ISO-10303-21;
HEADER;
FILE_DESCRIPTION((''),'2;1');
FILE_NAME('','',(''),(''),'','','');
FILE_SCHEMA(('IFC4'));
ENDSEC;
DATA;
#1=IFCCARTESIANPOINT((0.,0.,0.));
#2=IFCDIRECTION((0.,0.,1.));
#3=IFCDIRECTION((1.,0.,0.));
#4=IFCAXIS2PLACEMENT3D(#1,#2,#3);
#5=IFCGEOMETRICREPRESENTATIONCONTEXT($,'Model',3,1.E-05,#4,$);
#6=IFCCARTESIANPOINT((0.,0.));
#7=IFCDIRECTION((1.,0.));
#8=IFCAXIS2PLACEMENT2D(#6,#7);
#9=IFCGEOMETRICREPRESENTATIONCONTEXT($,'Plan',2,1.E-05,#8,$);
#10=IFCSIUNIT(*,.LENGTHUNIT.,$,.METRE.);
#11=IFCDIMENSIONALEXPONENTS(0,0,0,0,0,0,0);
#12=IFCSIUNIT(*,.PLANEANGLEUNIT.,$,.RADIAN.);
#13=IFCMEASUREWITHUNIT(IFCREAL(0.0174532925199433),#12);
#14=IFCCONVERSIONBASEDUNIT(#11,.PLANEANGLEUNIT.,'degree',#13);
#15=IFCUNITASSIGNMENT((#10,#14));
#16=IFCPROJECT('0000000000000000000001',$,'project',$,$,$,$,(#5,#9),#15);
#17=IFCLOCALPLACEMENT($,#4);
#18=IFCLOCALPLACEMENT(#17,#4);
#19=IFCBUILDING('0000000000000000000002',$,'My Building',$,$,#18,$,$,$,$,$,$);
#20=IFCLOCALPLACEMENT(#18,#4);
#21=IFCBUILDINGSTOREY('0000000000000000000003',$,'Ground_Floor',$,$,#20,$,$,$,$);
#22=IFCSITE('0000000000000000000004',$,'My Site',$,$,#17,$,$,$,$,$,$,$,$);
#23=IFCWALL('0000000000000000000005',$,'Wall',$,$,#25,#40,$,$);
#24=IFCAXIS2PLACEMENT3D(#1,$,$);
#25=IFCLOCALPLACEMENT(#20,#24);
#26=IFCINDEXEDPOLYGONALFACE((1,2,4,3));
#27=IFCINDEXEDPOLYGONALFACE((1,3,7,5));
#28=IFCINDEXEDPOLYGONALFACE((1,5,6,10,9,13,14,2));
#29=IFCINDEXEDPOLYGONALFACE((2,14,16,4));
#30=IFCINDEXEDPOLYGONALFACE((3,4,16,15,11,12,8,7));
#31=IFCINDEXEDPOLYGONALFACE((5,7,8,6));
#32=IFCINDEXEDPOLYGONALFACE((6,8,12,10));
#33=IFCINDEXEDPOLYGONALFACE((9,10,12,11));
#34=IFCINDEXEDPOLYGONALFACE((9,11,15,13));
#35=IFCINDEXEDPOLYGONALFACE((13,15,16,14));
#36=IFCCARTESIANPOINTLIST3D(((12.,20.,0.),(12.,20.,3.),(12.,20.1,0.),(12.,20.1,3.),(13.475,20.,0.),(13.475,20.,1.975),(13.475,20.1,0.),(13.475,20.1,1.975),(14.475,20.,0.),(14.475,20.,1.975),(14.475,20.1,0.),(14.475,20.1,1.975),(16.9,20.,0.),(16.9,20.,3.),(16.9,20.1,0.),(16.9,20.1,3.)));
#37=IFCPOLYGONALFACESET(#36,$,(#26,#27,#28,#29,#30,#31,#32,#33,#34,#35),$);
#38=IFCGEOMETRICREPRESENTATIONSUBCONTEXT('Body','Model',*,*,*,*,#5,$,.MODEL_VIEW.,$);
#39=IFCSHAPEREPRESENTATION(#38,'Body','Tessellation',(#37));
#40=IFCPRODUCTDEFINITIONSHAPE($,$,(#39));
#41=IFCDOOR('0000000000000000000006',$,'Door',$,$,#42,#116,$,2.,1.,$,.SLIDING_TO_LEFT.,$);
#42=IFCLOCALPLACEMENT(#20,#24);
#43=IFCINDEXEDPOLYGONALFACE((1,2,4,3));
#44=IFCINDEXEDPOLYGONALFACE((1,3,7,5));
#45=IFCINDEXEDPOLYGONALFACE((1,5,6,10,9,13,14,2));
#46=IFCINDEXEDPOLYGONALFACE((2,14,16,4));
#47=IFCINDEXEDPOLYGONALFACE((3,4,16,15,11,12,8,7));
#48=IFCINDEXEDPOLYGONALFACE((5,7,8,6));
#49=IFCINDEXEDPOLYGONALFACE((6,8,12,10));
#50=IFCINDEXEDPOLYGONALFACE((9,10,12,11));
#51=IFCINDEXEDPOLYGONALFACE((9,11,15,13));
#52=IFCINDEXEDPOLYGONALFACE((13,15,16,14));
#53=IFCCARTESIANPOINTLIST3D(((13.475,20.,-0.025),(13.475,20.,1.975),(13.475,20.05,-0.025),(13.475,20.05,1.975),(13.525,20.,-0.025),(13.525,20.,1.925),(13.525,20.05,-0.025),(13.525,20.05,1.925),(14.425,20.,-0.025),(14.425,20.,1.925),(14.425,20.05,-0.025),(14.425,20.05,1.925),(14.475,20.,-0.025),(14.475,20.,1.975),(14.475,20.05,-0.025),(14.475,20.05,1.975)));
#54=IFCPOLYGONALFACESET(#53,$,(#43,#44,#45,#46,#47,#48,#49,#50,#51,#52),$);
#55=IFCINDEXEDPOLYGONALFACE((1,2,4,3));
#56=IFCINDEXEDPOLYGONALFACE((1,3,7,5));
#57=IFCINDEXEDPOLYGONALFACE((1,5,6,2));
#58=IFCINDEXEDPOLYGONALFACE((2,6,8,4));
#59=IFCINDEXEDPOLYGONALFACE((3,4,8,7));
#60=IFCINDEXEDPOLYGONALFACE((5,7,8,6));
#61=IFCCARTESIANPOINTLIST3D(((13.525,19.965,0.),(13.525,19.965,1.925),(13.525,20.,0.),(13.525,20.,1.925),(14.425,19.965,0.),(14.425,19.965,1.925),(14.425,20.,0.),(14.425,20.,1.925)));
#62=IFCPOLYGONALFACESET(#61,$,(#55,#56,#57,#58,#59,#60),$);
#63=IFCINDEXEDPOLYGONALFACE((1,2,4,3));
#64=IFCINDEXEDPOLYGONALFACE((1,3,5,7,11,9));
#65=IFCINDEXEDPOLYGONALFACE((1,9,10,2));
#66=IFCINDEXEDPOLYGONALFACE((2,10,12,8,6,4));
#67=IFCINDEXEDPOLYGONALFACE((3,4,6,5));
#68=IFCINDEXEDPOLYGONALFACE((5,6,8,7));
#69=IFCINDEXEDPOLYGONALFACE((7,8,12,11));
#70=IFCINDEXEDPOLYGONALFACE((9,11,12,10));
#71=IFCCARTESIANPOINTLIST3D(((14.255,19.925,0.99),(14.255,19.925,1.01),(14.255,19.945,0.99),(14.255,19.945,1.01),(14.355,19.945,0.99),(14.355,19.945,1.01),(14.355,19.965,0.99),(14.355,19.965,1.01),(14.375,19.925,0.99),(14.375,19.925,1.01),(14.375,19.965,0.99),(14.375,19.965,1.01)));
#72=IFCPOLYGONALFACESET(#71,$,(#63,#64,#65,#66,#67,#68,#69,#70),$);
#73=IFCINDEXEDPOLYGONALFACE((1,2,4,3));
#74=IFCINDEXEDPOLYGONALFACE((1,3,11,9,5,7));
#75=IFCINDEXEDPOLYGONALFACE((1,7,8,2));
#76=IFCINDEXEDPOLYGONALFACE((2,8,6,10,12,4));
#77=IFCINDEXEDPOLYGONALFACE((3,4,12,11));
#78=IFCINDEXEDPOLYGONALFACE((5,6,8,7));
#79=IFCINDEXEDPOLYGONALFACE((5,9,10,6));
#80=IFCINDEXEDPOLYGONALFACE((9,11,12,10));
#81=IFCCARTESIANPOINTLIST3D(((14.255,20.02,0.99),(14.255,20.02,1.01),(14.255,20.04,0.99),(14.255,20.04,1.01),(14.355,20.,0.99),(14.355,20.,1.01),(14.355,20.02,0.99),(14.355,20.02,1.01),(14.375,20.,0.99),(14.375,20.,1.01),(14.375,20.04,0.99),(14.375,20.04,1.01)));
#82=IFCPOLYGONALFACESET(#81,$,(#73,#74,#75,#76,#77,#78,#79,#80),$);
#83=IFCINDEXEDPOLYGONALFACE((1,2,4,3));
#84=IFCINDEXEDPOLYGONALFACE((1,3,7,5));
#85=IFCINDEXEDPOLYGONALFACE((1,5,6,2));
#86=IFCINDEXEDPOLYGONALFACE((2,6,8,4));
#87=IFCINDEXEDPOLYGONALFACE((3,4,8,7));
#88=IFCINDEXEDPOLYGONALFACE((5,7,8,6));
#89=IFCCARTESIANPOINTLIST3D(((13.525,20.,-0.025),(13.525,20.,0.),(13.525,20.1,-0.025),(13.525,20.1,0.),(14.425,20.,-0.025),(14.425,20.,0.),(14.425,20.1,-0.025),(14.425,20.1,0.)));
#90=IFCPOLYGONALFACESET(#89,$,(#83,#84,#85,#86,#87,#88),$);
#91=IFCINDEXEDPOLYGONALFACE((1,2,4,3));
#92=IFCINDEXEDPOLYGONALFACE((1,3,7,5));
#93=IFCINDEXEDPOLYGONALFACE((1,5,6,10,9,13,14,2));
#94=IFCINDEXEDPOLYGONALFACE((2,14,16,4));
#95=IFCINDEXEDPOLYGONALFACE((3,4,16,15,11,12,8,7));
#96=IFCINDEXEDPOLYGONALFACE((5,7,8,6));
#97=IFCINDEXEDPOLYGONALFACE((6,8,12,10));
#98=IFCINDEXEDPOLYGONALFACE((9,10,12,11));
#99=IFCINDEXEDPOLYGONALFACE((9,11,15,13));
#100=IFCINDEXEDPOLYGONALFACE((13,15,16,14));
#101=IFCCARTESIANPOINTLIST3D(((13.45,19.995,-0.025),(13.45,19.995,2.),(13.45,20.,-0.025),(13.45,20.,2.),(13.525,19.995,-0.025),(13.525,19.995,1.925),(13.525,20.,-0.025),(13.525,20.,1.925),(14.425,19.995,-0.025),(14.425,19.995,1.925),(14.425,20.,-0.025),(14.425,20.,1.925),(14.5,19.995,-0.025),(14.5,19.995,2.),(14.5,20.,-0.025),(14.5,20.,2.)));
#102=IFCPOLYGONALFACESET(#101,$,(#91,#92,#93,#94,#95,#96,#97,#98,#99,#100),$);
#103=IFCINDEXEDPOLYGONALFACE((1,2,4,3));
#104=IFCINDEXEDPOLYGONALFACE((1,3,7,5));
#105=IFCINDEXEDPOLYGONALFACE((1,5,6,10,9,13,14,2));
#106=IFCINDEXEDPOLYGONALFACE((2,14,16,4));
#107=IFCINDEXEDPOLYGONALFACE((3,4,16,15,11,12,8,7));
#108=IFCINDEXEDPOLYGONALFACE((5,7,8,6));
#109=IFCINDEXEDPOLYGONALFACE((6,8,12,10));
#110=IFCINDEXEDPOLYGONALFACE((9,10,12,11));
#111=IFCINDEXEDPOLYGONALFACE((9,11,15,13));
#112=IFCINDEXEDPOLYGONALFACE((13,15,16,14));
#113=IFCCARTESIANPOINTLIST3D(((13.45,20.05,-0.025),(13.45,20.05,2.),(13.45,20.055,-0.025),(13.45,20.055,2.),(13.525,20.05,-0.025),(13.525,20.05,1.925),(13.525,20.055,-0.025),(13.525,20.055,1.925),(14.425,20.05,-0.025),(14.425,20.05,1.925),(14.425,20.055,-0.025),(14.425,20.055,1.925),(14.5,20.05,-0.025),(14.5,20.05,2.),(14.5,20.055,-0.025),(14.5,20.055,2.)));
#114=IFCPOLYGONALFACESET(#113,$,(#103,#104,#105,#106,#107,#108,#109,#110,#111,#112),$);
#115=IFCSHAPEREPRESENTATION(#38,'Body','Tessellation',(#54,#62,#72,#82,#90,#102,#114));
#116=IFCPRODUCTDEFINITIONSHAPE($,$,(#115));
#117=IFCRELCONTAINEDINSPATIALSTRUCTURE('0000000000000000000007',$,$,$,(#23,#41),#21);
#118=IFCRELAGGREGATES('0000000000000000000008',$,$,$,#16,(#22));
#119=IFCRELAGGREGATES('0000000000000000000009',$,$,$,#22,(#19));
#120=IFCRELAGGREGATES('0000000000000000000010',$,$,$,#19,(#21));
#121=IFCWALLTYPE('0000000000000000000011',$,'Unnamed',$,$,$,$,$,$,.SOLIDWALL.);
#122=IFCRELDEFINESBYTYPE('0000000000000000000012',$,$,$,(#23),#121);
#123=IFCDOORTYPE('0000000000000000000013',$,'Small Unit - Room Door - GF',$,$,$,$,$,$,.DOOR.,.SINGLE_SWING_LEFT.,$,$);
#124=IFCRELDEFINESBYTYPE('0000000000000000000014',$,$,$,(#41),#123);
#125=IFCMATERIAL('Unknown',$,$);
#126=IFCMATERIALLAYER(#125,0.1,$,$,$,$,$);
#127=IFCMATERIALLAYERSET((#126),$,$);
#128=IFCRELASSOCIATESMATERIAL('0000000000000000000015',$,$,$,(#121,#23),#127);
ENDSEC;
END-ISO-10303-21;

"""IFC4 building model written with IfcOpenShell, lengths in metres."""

from ifc_helpers import new_model, entity, si_unit, converted_unit, frame, origin_with_axes, origin_2d_with_axis, place, context, subcontext, project, spatial, line, indexed_curve, outline, extrude, shape, source, transform, mapped, material, layer, layer_set, layer_usage, type_object, type_shapes, element, fill, save


model = new_model("IFC4")

# Units and contexts
model_context = context("Model", 3, precision=1e-05, world=origin_with_axes())
plan_context = context("Plan", 2, precision=1e-05, world=origin_2d_with_axis())
body_context_1 = subcontext(model_context, "Body", "Model", "MODEL_VIEW")
body_context_2 = subcontext(plan_context, "Body", "Plan", "PLAN_VIEW")
ifc_project = project(units=[si_unit("LENGTHUNIT", "METRE"), converted_unit("PLANEANGLEUNIT", "degree", entity("IfcReal", 0.0174532925199433), si_unit("PLANEANGLEUNIT", "RADIAN"), dimensions=[0, 0, 0, 0, 0, 0, 0])], contexts=[model_context, plan_context])

# Site, building, storey
site_placement = place(None, origin_with_axes())
site = spatial("IfcSite", under=ifc_project, at=site_placement, Name="My Site")
building_placement = place(site_placement, origin_with_axes())
building = spatial("IfcBuilding", under=site, at=building_placement, Name="My Building")
storey_placement = place(building_placement, origin_with_axes())
storey = spatial("IfcBuildingStorey", under=building, at=storey_placement, Name="Ground_Floor")

# Shared definitions
ifc_material = material(Name="Unknown")
ifc_layer = layer(ifc_material, 0.1)
ifc_layer_set = layer_set([ifc_layer])
wall_type = type_object("IfcWallType", Name="Unnamed", PredefinedType="SOLIDWALL", material=ifc_layer_set)

# Wall, opening, door
shared_shape_1 = source(origin_with_axes(), body_context_1, "Body", "SweptSolid", [
    extrude(outline(indexed_curve([(0.0, 0.0), (1.0, 0.0), (1.0, 2.0), (0.0, 2.0)], segments=[line(1, 2, 3, 4, 1)])), frame((0.0, -0.6, 0.0), z_axis=(0.0, -1.0, 0.0), x_axis=(1.0, 0.0, 0.0)), (0.0, 0.0, -1.0), 1.2),
])
door_type_1 = type_object("IfcDoorType", Name="Small Unit - Room Door - GF", OperationType="SINGLE_SWING_LEFT", PredefinedType="DOOR")
shared_shape_2 = source(origin_with_axes(), body_context_1, "Body", "SweptSolid", [
    extrude(outline(indexed_curve([(0.0, 0.0), (0.0, 2.0), (1.0, 2.0), (1.0, 0.0), (0.95, 0.0), (0.95, 1.95), (0.05, 1.95), (0.05, 0.0)], segments=[line(1, 2, 3, 4, 5, 6, 7, 8, 1)])), frame((0.0, 0.0, 0.0), z_axis=(0.0, -1.0, 0.0), x_axis=(1.0, 0.0, 0.0)), (0.0, 0.0, -1.0), 0.05),
    extrude(outline(indexed_curve([(0.0, 0.0), (0.9, 0.0), (0.9, 0.035), (0.0, 0.035)], segments=[line(1, 2, 3, 4, 1)])), frame((0.05, -0.035, 0.025), z_axis=(0.0, 0.0, 1.0), x_axis=(1.0, 0.0, 0.0)), (0.0, 0.0, 1.0), 1.925),
    extrude(outline(indexed_curve([(0.0, 0.0), (0.0, -0.04), (-0.12, -0.04), (-0.12, -0.02), (-0.02, -0.02), (-0.02, 0.0)], segments=[line(1, 2, 3, 4, 5, 6, 1)])), frame((0.9, -0.035, 1.015), z_axis=(0.0, 0.0, 1.0), x_axis=(1.0, 0.0, 0.0)), (0.0, 0.0, 1.0), 0.02),
    extrude(outline(indexed_curve([(0.0, 0.0), (0.0, 0.04), (-0.12, 0.04), (-0.12, 0.02), (-0.02, 0.02), (-0.02, 0.0)], segments=[line(1, 2, 3, 4, 5, 6, 1)])), frame((0.9, 0.0, 1.015), z_axis=(0.0, 0.0, 1.0), x_axis=(1.0, 0.0, 0.0)), (0.0, 0.0, 1.0), 0.02),
    extrude(outline(indexed_curve([(0.0, 0.0), (0.9, 0.0), (0.9, 0.1), (0.0, 0.1)], segments=[line(1, 2, 3, 4, 1)])), frame((0.05, 0.0, 0.0), z_axis=(0.0, 0.0, 1.0), x_axis=(1.0, 0.0, 0.0)), (0.0, 0.0, 1.0), 0.025),
    extrude(outline(indexed_curve([(0.0, 0.0), (0.0, 2.025), (1.05, 2.025), (1.05, 0.0), (0.975, 0.0), (0.975, 1.95), (0.075, 1.95), (0.075, 0.0)], segments=[line(1, 2, 3, 4, 5, 6, 7, 8, 1)])), frame((-0.025, -0.005, 0.0), z_axis=(0.0, -1.0, 0.0), x_axis=(1.0, 0.0, 0.0)), (0.0, 0.0, -1.0), 0.005),
    extrude(outline(indexed_curve([(0.0, 0.0), (0.0, 2.025), (1.05, 2.025), (1.05, 0.0), (0.975, 0.0), (0.975, 1.95), (0.075, 1.95), (0.075, 0.0)], segments=[line(1, 2, 3, 4, 5, 6, 7, 8, 1)])), frame((-0.025, 0.05, 0.0), z_axis=(0.0, -1.0, 0.0), x_axis=(1.0, 0.0, 0.0)), (0.0, 0.0, -1.0), 0.005),
])
shared_shape_3 = source(origin_with_axes(), body_context_2, "Body", "Curve2D", [
    entity("IfcIndexedPolyCurve", entity("IfcCartesianPointList2D", [[0.0, 0.0], [0.05, 0.0], [0.05, 0.05], [0.0, 0.05]]), [entity("IfcLineIndex", [1, 2, 3, 4, 1])]),
    entity("IfcIndexedPolyCurve", entity("IfcCartesianPointList2D", [[1.0, 0.0], [0.95, 0.0], [0.95, 0.05], [1.0, 0.05]]), [entity("IfcLineIndex", [1, 2, 3, 4, 1])]),
    entity("IfcIndexedPolyCurve", entity("IfcCartesianPointList2D", [[-0.4, -0.035], [0.5, -0.035], [0.5, 0.0], [-0.4, 0.0]]), [entity("IfcLineIndex", [1, 2, 3, 4, 1])]),
])
type_shapes(door_type_1, [shared_shape_2, shared_shape_3])
ifc_layer_usage_1 = layer_usage(ifc_layer_set, "AXIS2", "POSITIVE", 0.0)
wall_1_placement = place(storey_placement, frame((12.0, 20.0, 0.0), z_axis=(0.0, 0.0, 1.0), x_axis=(1.0, 0.0, 0.0)))
wall_1 = element("IfcWall", 1, at=wall_1_placement, inside=storey, type_object=wall_type, material=ifc_layer_usage_1, Name="Wall", context=body_context_1, shape_type="SweptSolid", body=[
    extrude(outline(indexed_curve([(0.0, 0.0), (0.0, 0.1), (4.9, 0.1), (4.9, 0.0)], segments=[line(1, 2, 3, 4, 1)])), origin_with_axes(), (0.0, 0.0, 1.0), 3.0),
])
opening_1_placement = place(wall_1_placement, frame((1.475, 0.0, -0.025), z_axis=(0.0, 0.0, 1.0), x_axis=(1.0, 0.0, 0.0)))
opening_1 = element("IfcOpeningElement", 2, at=opening_1_placement, cuts=wall_1, PredefinedType="OPENING", context=body_context_1, shape_type="MappedRepresentation", body=[
    mapped(shared_shape_1, transform((0.0, 0.0, 0.0), x_axis=(1.0, 0.0, 0.0), y_axis=(0.0, 1.0, 0.0), z_axis=(0.0, 0.0, 1.0), scale=1.0)),
])
door_1_placement = place(opening_1_placement, frame((0.0, 0.0, 0.0), z_axis=(0.0, 0.0, 1.0), x_axis=(1.0, 0.0, 0.0)))
door_1 = element("IfcDoor", 3, at=door_1_placement, inside=storey, type_object=door_type_1, Name="Door", OperationType="SLIDING_TO_LEFT", OverallHeight=2.0, OverallWidth=1.0, shapes=[
    shape(body_context_1, "Body", "MappedRepresentation", [mapped(shared_shape_2, transform((0.0, 0.0, 0.0), x_axis=(1.0, 0.0, 0.0), y_axis=(0.0, 1.0, 0.0), z_axis=(0.0, 0.0, 1.0), scale=1.0))]),
    shape(body_context_2, "Body", "MappedRepresentation", [mapped(shared_shape_3, transform((0.0, 0.0, 0.0), x_axis=(1.0, 0.0, 0.0), y_axis=(0.0, 1.0, 0.0), z_axis=(0.0, 0.0, 1.0), scale=1.0))]),
])
fill(opening_1, door_1)

save(model, "model.ifc")
